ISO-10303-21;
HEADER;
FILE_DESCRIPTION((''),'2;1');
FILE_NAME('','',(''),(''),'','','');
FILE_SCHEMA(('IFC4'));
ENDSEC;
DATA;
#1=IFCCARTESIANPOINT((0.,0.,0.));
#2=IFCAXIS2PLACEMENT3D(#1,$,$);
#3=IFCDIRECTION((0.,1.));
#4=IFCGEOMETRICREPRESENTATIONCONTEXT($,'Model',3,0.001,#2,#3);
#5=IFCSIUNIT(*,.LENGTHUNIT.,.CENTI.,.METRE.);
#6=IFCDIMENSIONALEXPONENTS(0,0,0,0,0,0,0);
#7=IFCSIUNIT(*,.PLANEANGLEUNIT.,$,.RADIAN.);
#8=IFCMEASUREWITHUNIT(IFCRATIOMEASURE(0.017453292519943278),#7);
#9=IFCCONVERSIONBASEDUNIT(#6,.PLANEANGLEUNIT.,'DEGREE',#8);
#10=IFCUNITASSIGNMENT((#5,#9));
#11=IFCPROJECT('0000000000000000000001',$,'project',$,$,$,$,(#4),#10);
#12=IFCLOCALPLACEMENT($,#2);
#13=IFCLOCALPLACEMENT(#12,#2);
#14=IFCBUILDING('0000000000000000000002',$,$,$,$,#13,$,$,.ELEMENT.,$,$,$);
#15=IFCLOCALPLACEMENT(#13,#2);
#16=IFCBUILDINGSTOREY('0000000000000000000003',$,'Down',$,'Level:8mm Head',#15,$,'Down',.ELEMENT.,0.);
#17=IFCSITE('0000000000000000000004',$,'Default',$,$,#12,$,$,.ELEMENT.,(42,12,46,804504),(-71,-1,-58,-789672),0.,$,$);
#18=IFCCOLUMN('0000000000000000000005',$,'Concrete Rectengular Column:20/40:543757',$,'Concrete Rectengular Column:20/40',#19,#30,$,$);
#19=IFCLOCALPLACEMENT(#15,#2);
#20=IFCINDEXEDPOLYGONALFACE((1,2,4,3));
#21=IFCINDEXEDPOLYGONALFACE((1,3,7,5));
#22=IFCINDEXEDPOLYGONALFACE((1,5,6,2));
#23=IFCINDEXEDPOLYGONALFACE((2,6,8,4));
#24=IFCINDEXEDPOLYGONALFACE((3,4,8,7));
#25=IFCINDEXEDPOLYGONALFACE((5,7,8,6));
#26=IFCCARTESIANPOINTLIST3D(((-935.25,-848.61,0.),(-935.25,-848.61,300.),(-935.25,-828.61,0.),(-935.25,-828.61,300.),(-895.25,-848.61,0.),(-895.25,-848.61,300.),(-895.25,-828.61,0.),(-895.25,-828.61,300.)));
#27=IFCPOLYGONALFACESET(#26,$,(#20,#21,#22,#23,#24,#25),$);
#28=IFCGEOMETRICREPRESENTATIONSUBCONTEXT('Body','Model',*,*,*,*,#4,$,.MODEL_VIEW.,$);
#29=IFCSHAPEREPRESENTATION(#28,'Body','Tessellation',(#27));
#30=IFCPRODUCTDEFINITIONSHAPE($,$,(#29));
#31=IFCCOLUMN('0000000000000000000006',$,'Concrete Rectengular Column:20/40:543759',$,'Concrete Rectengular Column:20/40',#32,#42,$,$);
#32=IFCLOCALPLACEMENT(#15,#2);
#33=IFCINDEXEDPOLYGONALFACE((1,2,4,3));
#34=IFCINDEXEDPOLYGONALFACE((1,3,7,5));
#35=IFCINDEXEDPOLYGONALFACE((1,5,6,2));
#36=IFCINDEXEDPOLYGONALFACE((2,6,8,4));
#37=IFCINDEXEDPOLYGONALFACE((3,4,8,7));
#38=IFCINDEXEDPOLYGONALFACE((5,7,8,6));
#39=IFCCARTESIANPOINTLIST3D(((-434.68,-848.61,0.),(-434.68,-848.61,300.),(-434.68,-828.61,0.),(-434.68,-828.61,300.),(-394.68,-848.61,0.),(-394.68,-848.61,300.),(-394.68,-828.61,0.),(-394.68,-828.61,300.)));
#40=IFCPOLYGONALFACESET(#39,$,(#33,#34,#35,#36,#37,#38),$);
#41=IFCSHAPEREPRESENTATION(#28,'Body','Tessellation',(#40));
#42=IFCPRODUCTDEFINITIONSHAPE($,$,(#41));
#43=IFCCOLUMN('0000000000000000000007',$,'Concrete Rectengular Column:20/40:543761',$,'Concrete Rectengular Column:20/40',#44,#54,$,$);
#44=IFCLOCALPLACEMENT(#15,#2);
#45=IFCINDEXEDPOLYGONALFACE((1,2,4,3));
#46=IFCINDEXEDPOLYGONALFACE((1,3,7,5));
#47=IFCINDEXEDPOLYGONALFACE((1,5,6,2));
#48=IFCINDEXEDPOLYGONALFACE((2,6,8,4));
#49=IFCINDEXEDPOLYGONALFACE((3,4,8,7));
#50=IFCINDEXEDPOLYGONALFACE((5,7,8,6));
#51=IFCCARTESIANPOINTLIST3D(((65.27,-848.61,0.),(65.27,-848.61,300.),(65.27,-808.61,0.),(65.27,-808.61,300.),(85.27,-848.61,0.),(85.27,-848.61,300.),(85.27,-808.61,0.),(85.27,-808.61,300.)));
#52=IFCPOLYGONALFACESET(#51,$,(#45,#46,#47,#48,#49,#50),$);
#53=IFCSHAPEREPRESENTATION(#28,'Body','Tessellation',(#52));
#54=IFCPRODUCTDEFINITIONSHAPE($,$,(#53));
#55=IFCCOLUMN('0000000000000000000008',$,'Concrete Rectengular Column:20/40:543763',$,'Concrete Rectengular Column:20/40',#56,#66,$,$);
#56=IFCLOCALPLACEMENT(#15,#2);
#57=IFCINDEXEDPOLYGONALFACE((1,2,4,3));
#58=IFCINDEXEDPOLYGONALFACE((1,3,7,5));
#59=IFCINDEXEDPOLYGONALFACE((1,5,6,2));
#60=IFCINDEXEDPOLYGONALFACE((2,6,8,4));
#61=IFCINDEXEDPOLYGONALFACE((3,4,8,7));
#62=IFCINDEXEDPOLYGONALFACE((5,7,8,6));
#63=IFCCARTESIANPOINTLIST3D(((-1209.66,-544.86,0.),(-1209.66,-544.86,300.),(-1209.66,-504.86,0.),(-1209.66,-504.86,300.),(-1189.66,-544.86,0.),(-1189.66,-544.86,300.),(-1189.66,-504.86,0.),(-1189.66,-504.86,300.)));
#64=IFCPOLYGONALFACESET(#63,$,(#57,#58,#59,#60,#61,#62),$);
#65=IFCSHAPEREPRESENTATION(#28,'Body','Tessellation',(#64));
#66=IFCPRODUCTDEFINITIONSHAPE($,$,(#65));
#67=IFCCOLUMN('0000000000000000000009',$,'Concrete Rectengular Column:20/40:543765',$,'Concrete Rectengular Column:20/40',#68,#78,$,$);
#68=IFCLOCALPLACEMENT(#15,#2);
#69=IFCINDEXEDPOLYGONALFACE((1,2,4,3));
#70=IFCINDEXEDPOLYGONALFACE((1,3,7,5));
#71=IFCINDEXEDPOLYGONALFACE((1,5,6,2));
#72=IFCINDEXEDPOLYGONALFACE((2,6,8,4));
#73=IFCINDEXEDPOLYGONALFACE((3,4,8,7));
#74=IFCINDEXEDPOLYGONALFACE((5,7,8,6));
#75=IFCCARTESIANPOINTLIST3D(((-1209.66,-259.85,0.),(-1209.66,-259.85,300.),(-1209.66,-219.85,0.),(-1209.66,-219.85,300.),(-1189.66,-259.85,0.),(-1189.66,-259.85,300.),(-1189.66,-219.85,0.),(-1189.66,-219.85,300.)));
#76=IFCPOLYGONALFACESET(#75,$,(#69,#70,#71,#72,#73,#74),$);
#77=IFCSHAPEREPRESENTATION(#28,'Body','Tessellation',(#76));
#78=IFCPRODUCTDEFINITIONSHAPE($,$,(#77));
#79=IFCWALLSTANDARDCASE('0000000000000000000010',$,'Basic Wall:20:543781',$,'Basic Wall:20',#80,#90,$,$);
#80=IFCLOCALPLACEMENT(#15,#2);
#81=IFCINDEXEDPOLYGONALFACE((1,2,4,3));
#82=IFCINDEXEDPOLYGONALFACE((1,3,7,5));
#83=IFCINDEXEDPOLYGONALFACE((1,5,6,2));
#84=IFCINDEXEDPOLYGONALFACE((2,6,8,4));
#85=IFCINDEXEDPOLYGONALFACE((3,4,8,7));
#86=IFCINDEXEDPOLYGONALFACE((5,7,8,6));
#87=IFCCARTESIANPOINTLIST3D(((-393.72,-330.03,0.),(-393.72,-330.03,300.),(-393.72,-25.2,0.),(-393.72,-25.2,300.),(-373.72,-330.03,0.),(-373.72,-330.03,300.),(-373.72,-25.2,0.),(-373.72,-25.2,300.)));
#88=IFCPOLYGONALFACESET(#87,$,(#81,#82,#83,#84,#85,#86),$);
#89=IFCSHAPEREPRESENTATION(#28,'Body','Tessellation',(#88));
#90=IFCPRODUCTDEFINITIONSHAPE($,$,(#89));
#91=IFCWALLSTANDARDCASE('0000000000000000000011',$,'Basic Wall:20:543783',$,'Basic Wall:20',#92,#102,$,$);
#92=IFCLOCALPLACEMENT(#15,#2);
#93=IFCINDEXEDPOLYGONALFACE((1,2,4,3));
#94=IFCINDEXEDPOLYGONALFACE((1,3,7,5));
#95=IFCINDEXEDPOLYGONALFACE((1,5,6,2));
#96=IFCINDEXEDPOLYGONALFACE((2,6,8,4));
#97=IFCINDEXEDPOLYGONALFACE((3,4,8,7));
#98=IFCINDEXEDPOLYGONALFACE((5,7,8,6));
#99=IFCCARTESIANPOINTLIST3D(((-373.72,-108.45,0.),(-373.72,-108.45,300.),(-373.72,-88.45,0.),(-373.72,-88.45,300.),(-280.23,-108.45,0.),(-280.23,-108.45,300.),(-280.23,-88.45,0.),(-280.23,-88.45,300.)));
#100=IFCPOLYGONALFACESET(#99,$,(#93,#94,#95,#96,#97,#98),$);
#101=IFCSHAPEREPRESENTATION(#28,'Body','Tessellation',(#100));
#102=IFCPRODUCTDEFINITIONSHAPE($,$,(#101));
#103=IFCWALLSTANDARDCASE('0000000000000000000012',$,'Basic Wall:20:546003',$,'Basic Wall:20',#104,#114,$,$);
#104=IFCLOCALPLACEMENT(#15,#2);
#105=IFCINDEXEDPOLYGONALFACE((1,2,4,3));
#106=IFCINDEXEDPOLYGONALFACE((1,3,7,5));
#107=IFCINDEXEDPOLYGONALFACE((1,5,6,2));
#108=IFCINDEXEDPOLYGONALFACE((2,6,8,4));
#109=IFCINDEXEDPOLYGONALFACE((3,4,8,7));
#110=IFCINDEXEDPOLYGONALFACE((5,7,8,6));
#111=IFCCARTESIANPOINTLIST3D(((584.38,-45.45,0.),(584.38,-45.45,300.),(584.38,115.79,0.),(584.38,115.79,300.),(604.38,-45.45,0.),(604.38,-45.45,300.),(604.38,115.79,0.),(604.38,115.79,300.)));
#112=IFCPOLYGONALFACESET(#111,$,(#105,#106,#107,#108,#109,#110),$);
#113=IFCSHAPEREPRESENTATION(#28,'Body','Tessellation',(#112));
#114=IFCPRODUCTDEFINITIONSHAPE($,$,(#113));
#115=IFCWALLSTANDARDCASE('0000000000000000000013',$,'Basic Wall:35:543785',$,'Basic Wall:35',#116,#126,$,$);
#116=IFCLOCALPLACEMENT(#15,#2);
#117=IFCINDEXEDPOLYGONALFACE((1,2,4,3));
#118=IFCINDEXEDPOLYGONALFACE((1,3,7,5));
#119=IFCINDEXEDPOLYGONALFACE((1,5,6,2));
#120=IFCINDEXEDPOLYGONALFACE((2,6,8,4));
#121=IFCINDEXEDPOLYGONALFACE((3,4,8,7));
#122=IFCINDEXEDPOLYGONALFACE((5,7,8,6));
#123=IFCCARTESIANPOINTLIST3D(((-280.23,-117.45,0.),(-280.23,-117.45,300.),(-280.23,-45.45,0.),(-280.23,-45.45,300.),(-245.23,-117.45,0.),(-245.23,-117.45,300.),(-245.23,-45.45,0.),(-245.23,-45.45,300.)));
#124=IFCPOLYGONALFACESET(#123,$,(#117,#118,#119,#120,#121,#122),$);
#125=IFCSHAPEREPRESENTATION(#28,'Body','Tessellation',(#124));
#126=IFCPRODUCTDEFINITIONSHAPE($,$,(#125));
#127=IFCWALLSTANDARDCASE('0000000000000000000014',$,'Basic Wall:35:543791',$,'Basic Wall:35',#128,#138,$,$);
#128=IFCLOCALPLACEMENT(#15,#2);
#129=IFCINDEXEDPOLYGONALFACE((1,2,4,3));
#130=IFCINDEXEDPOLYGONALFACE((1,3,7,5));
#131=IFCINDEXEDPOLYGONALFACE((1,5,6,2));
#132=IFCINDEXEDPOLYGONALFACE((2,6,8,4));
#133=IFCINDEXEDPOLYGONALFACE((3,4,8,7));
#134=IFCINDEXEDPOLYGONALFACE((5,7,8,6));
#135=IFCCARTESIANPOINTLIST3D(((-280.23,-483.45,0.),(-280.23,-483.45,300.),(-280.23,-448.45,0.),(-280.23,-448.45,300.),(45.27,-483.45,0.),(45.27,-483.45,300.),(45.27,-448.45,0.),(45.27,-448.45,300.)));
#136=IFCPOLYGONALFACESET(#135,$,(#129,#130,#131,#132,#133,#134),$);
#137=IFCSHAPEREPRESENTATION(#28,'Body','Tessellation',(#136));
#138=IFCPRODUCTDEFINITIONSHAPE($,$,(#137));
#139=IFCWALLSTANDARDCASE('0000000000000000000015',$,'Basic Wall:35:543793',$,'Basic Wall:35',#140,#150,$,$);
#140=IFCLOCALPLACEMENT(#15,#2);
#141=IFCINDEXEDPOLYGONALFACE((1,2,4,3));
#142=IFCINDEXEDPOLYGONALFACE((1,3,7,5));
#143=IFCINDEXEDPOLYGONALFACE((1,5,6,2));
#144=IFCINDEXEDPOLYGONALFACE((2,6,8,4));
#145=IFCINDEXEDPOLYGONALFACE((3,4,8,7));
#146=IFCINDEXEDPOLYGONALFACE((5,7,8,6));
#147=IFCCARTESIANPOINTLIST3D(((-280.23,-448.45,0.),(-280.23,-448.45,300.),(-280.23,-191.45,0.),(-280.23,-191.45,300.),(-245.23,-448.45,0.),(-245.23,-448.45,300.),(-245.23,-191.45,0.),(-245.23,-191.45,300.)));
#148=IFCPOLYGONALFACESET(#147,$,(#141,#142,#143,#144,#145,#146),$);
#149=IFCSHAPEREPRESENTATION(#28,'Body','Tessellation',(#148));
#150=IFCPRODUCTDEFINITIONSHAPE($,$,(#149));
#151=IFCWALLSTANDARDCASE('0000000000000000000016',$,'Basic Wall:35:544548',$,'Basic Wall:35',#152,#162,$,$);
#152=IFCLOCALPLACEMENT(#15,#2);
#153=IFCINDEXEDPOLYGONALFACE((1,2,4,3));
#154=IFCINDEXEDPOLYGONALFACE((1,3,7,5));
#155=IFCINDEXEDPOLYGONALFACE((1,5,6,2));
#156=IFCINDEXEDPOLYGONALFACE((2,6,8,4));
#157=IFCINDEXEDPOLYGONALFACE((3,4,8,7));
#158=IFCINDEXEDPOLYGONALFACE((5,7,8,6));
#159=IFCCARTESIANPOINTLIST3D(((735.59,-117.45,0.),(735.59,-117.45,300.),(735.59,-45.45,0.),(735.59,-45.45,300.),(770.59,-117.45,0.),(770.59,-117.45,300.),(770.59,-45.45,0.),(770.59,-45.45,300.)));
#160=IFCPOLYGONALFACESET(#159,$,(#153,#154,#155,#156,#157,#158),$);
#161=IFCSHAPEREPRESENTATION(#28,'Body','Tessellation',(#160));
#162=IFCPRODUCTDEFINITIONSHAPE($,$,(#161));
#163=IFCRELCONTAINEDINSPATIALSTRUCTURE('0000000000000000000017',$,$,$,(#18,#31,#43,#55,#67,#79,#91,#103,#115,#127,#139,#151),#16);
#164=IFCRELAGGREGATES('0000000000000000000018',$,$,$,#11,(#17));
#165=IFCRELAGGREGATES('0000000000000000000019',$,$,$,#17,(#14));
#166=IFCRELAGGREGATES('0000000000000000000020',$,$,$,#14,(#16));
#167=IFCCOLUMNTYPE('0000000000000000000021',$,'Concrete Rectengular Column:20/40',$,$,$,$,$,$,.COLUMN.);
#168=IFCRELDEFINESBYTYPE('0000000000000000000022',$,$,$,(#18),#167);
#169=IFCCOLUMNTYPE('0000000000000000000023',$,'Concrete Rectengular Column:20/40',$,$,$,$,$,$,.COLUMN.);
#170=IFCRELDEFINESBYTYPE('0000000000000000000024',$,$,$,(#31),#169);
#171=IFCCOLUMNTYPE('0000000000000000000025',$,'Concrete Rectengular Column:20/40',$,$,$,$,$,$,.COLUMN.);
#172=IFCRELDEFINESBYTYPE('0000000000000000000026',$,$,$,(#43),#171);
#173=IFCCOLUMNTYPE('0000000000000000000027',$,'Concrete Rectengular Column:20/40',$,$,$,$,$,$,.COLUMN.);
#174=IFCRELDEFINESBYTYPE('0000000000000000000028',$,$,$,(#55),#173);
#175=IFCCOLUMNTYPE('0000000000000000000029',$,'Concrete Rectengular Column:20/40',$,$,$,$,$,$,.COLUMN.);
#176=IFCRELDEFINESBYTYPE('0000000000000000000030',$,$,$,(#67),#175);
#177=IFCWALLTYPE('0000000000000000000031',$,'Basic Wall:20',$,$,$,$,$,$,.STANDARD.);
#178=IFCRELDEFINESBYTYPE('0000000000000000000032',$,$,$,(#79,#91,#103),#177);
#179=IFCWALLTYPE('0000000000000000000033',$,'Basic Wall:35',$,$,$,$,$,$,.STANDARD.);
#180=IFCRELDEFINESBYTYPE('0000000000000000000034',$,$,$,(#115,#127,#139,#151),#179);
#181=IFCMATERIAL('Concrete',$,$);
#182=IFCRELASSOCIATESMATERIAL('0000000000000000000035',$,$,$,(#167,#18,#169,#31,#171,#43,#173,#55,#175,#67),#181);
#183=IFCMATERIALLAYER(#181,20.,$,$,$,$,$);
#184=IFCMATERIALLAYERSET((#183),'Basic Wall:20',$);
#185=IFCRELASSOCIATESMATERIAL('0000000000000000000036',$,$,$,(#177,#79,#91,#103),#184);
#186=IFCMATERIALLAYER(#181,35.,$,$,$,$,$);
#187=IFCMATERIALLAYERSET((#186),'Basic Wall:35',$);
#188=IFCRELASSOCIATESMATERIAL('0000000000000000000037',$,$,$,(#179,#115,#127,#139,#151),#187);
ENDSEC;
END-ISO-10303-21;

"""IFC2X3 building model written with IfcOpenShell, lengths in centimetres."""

from ifc_helpers import new_model, entity, si_unit, converted_unit, direction, frame, frame_2d, origin, origin_2d_with_axis, place, context, subcontext, project, spatial, rectangle, extrude, source, transform, mapped, material, layer, layer_set, layer_usage, type_object, type_shapes, element, save


model = new_model("IFC2X3")

# Units and contexts
model_context = context("Model", 3, precision=0.001, world=origin(), true_north=direction((0.0, 1.0)))
body_context = subcontext(model_context, "Body", "Model", "MODEL_VIEW")
ifc_project = project(units=[si_unit("LENGTHUNIT", "METRE", prefix="CENTI"), converted_unit("PLANEANGLEUNIT", "DEGREE", entity("IfcRatioMeasure", 0.017453292519943278), si_unit("PLANEANGLEUNIT", "RADIAN"), dimensions=[0, 0, 0, 0, 0, 0, 0])], contexts=[model_context])

# Site, building, storey
site_placement = place(None, origin())
site = spatial("IfcSite", under=ifc_project, at=site_placement, Name="Default", CompositionType="ELEMENT", RefLatitude=(42, 12, 46, 804504), RefLongitude=(-71, -1, -58, -789672), RefElevation=0.0)
building_placement = place(site_placement, origin())
building = spatial("IfcBuilding", under=site, at=building_placement, CompositionType="ELEMENT")
storey_placement = place(building_placement, origin())
storey = spatial("IfcBuildingStorey", under=building, at=storey_placement, Name="Down", ObjectType="Level:8mm Head", LongName="Down", CompositionType="ELEMENT", Elevation=0.0)

# Columns
ifc_material = material(Name="Concrete")
column_type_1 = type_object("IfcColumnType", Name="Concrete Rectengular Column:20/40", PredefinedType="COLUMN", material=ifc_material)
shared_shape_1 = source(origin(), body_context, "Body", "SweptSolid", [
    extrude(rectangle(XDim=20.0, YDim=40.0, at=frame_2d((0.0, 0.0), x_axis=(1.0, 0.0))), frame((-915.25, -838.61, 0.0), z_axis=(0.0, 0.0, 1.0), x_axis=(0.0, -1.0, 0.0)), (0.0, 0.0, 1.0), 300.0),
])
type_shapes(column_type_1, [shared_shape_1])
column_1_placement = place(storey_placement, origin())
element("IfcColumn", 1, at=column_1_placement, inside=storey, type_object=column_type_1, material=ifc_material, Name="Concrete Rectengular Column:20/40:543757", ObjectType="Concrete Rectengular Column:20/40", context=body_context, shape_type="MappedRepresentation", body=[
    mapped(shared_shape_1, transform((0.0, 0.0, 0.0), scale=1.0)),
])
column_type_2 = type_object("IfcColumnType", Name="Concrete Rectengular Column:20/40", PredefinedType="COLUMN", material=ifc_material)
shared_shape_2 = source(origin(), body_context, "Body", "SweptSolid", [
    extrude(rectangle(XDim=20.0, YDim=40.0, at=origin_2d_with_axis()), frame((-414.68, -838.61, 0.0), z_axis=(0.0, 0.0, 1.0), x_axis=(0.0, -1.0, 0.0)), (0.0, 0.0, 1.0), 300.0),
])
type_shapes(column_type_2, [shared_shape_2])
column_2_placement = place(storey_placement, origin())
element("IfcColumn", 2, at=column_2_placement, inside=storey, type_object=column_type_2, material=ifc_material, Name="Concrete Rectengular Column:20/40:543759", ObjectType="Concrete Rectengular Column:20/40", context=body_context, shape_type="MappedRepresentation", body=[
    mapped(shared_shape_2, transform((0.0, 0.0, 0.0), scale=1.0)),
])
column_type_3 = type_object("IfcColumnType", Name="Concrete Rectengular Column:20/40", PredefinedType="COLUMN", material=ifc_material)
shared_shape_3 = source(origin(), body_context, "Body", "SweptSolid", [
    extrude(rectangle(XDim=40.0, YDim=20.0, at=frame_2d((0.0, 0.0), x_axis=(1.0, 0.0))), frame((75.27, -828.61, 0.0), z_axis=(0.0, 0.0, 1.0), x_axis=(0.0, -1.0, 0.0)), (0.0, 0.0, 1.0), 300.0),
])
type_shapes(column_type_3, [shared_shape_3])
column_3_placement = place(storey_placement, origin())
element("IfcColumn", 3, at=column_3_placement, inside=storey, type_object=column_type_3, material=ifc_material, Name="Concrete Rectengular Column:20/40:543761", ObjectType="Concrete Rectengular Column:20/40", context=body_context, shape_type="MappedRepresentation", body=[
    mapped(shared_shape_3, transform((0.0, 0.0, 0.0), scale=1.0)),
])
column_type_4 = type_object("IfcColumnType", Name="Concrete Rectengular Column:20/40", PredefinedType="COLUMN", material=ifc_material)
shared_shape_4 = source(origin(), body_context, "Body", "SweptSolid", [
    extrude(rectangle(XDim=40.0, YDim=20.0, at=frame_2d((0.0, 0.0), x_axis=(1.0, 0.0))), frame((-1199.66, -524.86, 0.0), z_axis=(0.0, 0.0, 1.0), x_axis=(0.0, -1.0, 0.0)), (0.0, 0.0, 1.0), 300.0),
])
type_shapes(column_type_4, [shared_shape_4])
column_4_placement = place(storey_placement, origin())
element("IfcColumn", 4, at=column_4_placement, inside=storey, type_object=column_type_4, material=ifc_material, Name="Concrete Rectengular Column:20/40:543763", ObjectType="Concrete Rectengular Column:20/40", context=body_context, shape_type="MappedRepresentation", body=[
    mapped(shared_shape_4, transform((0.0, 0.0, 0.0), scale=1.0)),
])
column_type_5 = type_object("IfcColumnType", Name="Concrete Rectengular Column:20/40", PredefinedType="COLUMN", material=ifc_material)
shared_shape_5 = source(origin(), body_context, "Body", "SweptSolid", [
    extrude(rectangle(XDim=40.0, YDim=20.0, at=frame_2d((0.0, 0.0), x_axis=(1.0, 0.0))), frame((-1199.66, -239.85, 0.0), z_axis=(0.0, 0.0, 1.0), x_axis=(0.0, -1.0, 0.0)), (0.0, 0.0, 1.0), 300.0),
])
type_shapes(column_type_5, [shared_shape_5])
column_5_placement = place(storey_placement, origin())
element("IfcColumn", 5, at=column_5_placement, inside=storey, type_object=column_type_5, material=ifc_material, Name="Concrete Rectengular Column:20/40:543765", ObjectType="Concrete Rectengular Column:20/40", context=body_context, shape_type="MappedRepresentation", body=[
    mapped(shared_shape_5, transform((0.0, 0.0, 0.0), scale=1.0)),
])

# Walls
ifc_layer_1 = layer(ifc_material, 20.0)
ifc_layer_set_1 = layer_set([ifc_layer_1], Name="Basic Wall:20")
ifc_layer_usage_1 = layer_usage(ifc_layer_set_1, "AXIS2", "NEGATIVE", 10.0)
wall_type_1 = type_object("IfcWallType", Name="Basic Wall:20", PredefinedType="STANDARD", material=ifc_layer_set_1)
wall_1_placement = place(storey_placement, frame((-383.72, -330.03, 0.0), z_axis=(0.0, 0.0, 1.0), x_axis=(0.0, 1.0, 0.0)))
element("IfcWallStandardCase", 6, at=wall_1_placement, inside=storey, type_object=wall_type_1, material=ifc_layer_usage_1, Name="Basic Wall:20:543781", ObjectType="Basic Wall:20", context=body_context, shape_type="SweptSolid", body=[
    extrude(rectangle(XDim=304.83, YDim=20.0, at=frame_2d((152.41, 0.0), x_axis=(-1.0, 0.0))), origin(), (0.0, 0.0, 1.0), 300.0),
])
ifc_layer_usage_2 = layer_usage(ifc_layer_set_1, "AXIS2", "POSITIVE", -10.0)
wall_2_placement = place(storey_placement, frame((-373.72, -98.45, 0.0)))
element("IfcWallStandardCase", 7, at=wall_2_placement, inside=storey, type_object=wall_type_1, material=ifc_layer_usage_2, Name="Basic Wall:20:543783", ObjectType="Basic Wall:20", context=body_context, shape_type="SweptSolid", body=[
    extrude(rectangle(XDim=93.49, YDim=20.0, at=frame_2d((46.75, 0.0), x_axis=(-1.0, 0.0))), origin(), (0.0, 0.0, 1.0), 300.0),
])
ifc_layer_usage_3 = layer_usage(ifc_layer_set_1, "AXIS2", "NEGATIVE", 10.0)
wall_3_placement = place(storey_placement, frame((594.38, -45.45, 0.0), z_axis=(0.0, 0.0, 1.0), x_axis=(0.0, 1.0, 0.0)))
element("IfcWallStandardCase", 8, at=wall_3_placement, inside=storey, type_object=wall_type_1, material=ifc_layer_usage_3, Name="Basic Wall:20:546003", ObjectType="Basic Wall:20", context=body_context, shape_type="SweptSolid", body=[
    extrude(rectangle(XDim=161.24, YDim=20.0, at=frame_2d((80.62, 0.0), x_axis=(-1.0, 0.0))), origin(), (0.0, 0.0, 1.0), 300.0),
])
ifc_layer_2 = layer(ifc_material, 35.0)
ifc_layer_set_2 = layer_set([ifc_layer_2], Name="Basic Wall:35")
ifc_layer_usage_4 = layer_usage(ifc_layer_set_2, "AXIS2", "NEGATIVE", 17.5)
wall_type_2 = type_object("IfcWallType", Name="Basic Wall:35", PredefinedType="STANDARD", material=ifc_layer_set_2)
wall_4_placement = place(storey_placement, frame((-262.73, -117.45, 0.0), z_axis=(0.0, 0.0, 1.0), x_axis=(0.0, 1.0, 0.0)))
element("IfcWallStandardCase", 9, at=wall_4_placement, inside=storey, type_object=wall_type_2, material=ifc_layer_usage_4, Name="Basic Wall:35:543785", ObjectType="Basic Wall:35", context=body_context, shape_type="SweptSolid", body=[
    extrude(rectangle(XDim=72.0, YDim=35.0, at=frame_2d((36.0, 0.0), x_axis=(-1.0, 0.0))), origin(), (0.0, 0.0, 1.0), 300.0),
])
ifc_layer_usage_5 = layer_usage(ifc_layer_set_2, "AXIS2", "NEGATIVE", 17.5)
wall_5_placement = place(storey_placement, frame((45.27, -465.95, 0.0), z_axis=(0.0, 0.0, 1.0), x_axis=(-1.0, 0.0, 0.0)))
element("IfcWallStandardCase", 10, at=wall_5_placement, inside=storey, type_object=wall_type_2, material=ifc_layer_usage_5, Name="Basic Wall:35:543791", ObjectType="Basic Wall:35", context=body_context, shape_type="SweptSolid", body=[
    extrude(rectangle(XDim=325.5, YDim=35.0, at=frame_2d((162.75, 0.0), x_axis=(-1.0, 0.0))), origin(), (0.0, 0.0, 1.0), 300.0),
])
ifc_layer_usage_6 = layer_usage(ifc_layer_set_2, "AXIS2", "NEGATIVE", 17.5)
wall_6_placement = place(storey_placement, frame((-262.73, -448.45, 0.0), z_axis=(0.0, 0.0, 1.0), x_axis=(0.0, 1.0, 0.0)))
element("IfcWallStandardCase", 11, at=wall_6_placement, inside=storey, type_object=wall_type_2, material=ifc_layer_usage_6, Name="Basic Wall:35:543793", ObjectType="Basic Wall:35", context=body_context, shape_type="SweptSolid", body=[
    extrude(rectangle(XDim=257.0, YDim=35.0, at=frame_2d((128.5, 0.0), x_axis=(-1.0, 0.0))), origin(), (0.0, 0.0, 1.0), 300.0),
])
ifc_layer_usage_7 = layer_usage(ifc_layer_set_2, "AXIS2", "POSITIVE", -17.5)
wall_7_placement = place(storey_placement, frame((753.09, -117.45, 0.0), z_axis=(0.0, 0.0, 1.0), x_axis=(0.0, 1.0, 0.0)))
element("IfcWallStandardCase", 12, at=wall_7_placement, inside=storey, type_object=wall_type_2, material=ifc_layer_usage_7, Name="Basic Wall:35:544548", ObjectType="Basic Wall:35", context=body_context, shape_type="SweptSolid", body=[
    extrude(rectangle(XDim=72.0, YDim=35.0, at=frame_2d((36.0, 0.0), x_axis=(-1.0, 0.0))), origin(), (0.0, 0.0, 1.0), 300.0),
])

save(model, "model.ifc")
